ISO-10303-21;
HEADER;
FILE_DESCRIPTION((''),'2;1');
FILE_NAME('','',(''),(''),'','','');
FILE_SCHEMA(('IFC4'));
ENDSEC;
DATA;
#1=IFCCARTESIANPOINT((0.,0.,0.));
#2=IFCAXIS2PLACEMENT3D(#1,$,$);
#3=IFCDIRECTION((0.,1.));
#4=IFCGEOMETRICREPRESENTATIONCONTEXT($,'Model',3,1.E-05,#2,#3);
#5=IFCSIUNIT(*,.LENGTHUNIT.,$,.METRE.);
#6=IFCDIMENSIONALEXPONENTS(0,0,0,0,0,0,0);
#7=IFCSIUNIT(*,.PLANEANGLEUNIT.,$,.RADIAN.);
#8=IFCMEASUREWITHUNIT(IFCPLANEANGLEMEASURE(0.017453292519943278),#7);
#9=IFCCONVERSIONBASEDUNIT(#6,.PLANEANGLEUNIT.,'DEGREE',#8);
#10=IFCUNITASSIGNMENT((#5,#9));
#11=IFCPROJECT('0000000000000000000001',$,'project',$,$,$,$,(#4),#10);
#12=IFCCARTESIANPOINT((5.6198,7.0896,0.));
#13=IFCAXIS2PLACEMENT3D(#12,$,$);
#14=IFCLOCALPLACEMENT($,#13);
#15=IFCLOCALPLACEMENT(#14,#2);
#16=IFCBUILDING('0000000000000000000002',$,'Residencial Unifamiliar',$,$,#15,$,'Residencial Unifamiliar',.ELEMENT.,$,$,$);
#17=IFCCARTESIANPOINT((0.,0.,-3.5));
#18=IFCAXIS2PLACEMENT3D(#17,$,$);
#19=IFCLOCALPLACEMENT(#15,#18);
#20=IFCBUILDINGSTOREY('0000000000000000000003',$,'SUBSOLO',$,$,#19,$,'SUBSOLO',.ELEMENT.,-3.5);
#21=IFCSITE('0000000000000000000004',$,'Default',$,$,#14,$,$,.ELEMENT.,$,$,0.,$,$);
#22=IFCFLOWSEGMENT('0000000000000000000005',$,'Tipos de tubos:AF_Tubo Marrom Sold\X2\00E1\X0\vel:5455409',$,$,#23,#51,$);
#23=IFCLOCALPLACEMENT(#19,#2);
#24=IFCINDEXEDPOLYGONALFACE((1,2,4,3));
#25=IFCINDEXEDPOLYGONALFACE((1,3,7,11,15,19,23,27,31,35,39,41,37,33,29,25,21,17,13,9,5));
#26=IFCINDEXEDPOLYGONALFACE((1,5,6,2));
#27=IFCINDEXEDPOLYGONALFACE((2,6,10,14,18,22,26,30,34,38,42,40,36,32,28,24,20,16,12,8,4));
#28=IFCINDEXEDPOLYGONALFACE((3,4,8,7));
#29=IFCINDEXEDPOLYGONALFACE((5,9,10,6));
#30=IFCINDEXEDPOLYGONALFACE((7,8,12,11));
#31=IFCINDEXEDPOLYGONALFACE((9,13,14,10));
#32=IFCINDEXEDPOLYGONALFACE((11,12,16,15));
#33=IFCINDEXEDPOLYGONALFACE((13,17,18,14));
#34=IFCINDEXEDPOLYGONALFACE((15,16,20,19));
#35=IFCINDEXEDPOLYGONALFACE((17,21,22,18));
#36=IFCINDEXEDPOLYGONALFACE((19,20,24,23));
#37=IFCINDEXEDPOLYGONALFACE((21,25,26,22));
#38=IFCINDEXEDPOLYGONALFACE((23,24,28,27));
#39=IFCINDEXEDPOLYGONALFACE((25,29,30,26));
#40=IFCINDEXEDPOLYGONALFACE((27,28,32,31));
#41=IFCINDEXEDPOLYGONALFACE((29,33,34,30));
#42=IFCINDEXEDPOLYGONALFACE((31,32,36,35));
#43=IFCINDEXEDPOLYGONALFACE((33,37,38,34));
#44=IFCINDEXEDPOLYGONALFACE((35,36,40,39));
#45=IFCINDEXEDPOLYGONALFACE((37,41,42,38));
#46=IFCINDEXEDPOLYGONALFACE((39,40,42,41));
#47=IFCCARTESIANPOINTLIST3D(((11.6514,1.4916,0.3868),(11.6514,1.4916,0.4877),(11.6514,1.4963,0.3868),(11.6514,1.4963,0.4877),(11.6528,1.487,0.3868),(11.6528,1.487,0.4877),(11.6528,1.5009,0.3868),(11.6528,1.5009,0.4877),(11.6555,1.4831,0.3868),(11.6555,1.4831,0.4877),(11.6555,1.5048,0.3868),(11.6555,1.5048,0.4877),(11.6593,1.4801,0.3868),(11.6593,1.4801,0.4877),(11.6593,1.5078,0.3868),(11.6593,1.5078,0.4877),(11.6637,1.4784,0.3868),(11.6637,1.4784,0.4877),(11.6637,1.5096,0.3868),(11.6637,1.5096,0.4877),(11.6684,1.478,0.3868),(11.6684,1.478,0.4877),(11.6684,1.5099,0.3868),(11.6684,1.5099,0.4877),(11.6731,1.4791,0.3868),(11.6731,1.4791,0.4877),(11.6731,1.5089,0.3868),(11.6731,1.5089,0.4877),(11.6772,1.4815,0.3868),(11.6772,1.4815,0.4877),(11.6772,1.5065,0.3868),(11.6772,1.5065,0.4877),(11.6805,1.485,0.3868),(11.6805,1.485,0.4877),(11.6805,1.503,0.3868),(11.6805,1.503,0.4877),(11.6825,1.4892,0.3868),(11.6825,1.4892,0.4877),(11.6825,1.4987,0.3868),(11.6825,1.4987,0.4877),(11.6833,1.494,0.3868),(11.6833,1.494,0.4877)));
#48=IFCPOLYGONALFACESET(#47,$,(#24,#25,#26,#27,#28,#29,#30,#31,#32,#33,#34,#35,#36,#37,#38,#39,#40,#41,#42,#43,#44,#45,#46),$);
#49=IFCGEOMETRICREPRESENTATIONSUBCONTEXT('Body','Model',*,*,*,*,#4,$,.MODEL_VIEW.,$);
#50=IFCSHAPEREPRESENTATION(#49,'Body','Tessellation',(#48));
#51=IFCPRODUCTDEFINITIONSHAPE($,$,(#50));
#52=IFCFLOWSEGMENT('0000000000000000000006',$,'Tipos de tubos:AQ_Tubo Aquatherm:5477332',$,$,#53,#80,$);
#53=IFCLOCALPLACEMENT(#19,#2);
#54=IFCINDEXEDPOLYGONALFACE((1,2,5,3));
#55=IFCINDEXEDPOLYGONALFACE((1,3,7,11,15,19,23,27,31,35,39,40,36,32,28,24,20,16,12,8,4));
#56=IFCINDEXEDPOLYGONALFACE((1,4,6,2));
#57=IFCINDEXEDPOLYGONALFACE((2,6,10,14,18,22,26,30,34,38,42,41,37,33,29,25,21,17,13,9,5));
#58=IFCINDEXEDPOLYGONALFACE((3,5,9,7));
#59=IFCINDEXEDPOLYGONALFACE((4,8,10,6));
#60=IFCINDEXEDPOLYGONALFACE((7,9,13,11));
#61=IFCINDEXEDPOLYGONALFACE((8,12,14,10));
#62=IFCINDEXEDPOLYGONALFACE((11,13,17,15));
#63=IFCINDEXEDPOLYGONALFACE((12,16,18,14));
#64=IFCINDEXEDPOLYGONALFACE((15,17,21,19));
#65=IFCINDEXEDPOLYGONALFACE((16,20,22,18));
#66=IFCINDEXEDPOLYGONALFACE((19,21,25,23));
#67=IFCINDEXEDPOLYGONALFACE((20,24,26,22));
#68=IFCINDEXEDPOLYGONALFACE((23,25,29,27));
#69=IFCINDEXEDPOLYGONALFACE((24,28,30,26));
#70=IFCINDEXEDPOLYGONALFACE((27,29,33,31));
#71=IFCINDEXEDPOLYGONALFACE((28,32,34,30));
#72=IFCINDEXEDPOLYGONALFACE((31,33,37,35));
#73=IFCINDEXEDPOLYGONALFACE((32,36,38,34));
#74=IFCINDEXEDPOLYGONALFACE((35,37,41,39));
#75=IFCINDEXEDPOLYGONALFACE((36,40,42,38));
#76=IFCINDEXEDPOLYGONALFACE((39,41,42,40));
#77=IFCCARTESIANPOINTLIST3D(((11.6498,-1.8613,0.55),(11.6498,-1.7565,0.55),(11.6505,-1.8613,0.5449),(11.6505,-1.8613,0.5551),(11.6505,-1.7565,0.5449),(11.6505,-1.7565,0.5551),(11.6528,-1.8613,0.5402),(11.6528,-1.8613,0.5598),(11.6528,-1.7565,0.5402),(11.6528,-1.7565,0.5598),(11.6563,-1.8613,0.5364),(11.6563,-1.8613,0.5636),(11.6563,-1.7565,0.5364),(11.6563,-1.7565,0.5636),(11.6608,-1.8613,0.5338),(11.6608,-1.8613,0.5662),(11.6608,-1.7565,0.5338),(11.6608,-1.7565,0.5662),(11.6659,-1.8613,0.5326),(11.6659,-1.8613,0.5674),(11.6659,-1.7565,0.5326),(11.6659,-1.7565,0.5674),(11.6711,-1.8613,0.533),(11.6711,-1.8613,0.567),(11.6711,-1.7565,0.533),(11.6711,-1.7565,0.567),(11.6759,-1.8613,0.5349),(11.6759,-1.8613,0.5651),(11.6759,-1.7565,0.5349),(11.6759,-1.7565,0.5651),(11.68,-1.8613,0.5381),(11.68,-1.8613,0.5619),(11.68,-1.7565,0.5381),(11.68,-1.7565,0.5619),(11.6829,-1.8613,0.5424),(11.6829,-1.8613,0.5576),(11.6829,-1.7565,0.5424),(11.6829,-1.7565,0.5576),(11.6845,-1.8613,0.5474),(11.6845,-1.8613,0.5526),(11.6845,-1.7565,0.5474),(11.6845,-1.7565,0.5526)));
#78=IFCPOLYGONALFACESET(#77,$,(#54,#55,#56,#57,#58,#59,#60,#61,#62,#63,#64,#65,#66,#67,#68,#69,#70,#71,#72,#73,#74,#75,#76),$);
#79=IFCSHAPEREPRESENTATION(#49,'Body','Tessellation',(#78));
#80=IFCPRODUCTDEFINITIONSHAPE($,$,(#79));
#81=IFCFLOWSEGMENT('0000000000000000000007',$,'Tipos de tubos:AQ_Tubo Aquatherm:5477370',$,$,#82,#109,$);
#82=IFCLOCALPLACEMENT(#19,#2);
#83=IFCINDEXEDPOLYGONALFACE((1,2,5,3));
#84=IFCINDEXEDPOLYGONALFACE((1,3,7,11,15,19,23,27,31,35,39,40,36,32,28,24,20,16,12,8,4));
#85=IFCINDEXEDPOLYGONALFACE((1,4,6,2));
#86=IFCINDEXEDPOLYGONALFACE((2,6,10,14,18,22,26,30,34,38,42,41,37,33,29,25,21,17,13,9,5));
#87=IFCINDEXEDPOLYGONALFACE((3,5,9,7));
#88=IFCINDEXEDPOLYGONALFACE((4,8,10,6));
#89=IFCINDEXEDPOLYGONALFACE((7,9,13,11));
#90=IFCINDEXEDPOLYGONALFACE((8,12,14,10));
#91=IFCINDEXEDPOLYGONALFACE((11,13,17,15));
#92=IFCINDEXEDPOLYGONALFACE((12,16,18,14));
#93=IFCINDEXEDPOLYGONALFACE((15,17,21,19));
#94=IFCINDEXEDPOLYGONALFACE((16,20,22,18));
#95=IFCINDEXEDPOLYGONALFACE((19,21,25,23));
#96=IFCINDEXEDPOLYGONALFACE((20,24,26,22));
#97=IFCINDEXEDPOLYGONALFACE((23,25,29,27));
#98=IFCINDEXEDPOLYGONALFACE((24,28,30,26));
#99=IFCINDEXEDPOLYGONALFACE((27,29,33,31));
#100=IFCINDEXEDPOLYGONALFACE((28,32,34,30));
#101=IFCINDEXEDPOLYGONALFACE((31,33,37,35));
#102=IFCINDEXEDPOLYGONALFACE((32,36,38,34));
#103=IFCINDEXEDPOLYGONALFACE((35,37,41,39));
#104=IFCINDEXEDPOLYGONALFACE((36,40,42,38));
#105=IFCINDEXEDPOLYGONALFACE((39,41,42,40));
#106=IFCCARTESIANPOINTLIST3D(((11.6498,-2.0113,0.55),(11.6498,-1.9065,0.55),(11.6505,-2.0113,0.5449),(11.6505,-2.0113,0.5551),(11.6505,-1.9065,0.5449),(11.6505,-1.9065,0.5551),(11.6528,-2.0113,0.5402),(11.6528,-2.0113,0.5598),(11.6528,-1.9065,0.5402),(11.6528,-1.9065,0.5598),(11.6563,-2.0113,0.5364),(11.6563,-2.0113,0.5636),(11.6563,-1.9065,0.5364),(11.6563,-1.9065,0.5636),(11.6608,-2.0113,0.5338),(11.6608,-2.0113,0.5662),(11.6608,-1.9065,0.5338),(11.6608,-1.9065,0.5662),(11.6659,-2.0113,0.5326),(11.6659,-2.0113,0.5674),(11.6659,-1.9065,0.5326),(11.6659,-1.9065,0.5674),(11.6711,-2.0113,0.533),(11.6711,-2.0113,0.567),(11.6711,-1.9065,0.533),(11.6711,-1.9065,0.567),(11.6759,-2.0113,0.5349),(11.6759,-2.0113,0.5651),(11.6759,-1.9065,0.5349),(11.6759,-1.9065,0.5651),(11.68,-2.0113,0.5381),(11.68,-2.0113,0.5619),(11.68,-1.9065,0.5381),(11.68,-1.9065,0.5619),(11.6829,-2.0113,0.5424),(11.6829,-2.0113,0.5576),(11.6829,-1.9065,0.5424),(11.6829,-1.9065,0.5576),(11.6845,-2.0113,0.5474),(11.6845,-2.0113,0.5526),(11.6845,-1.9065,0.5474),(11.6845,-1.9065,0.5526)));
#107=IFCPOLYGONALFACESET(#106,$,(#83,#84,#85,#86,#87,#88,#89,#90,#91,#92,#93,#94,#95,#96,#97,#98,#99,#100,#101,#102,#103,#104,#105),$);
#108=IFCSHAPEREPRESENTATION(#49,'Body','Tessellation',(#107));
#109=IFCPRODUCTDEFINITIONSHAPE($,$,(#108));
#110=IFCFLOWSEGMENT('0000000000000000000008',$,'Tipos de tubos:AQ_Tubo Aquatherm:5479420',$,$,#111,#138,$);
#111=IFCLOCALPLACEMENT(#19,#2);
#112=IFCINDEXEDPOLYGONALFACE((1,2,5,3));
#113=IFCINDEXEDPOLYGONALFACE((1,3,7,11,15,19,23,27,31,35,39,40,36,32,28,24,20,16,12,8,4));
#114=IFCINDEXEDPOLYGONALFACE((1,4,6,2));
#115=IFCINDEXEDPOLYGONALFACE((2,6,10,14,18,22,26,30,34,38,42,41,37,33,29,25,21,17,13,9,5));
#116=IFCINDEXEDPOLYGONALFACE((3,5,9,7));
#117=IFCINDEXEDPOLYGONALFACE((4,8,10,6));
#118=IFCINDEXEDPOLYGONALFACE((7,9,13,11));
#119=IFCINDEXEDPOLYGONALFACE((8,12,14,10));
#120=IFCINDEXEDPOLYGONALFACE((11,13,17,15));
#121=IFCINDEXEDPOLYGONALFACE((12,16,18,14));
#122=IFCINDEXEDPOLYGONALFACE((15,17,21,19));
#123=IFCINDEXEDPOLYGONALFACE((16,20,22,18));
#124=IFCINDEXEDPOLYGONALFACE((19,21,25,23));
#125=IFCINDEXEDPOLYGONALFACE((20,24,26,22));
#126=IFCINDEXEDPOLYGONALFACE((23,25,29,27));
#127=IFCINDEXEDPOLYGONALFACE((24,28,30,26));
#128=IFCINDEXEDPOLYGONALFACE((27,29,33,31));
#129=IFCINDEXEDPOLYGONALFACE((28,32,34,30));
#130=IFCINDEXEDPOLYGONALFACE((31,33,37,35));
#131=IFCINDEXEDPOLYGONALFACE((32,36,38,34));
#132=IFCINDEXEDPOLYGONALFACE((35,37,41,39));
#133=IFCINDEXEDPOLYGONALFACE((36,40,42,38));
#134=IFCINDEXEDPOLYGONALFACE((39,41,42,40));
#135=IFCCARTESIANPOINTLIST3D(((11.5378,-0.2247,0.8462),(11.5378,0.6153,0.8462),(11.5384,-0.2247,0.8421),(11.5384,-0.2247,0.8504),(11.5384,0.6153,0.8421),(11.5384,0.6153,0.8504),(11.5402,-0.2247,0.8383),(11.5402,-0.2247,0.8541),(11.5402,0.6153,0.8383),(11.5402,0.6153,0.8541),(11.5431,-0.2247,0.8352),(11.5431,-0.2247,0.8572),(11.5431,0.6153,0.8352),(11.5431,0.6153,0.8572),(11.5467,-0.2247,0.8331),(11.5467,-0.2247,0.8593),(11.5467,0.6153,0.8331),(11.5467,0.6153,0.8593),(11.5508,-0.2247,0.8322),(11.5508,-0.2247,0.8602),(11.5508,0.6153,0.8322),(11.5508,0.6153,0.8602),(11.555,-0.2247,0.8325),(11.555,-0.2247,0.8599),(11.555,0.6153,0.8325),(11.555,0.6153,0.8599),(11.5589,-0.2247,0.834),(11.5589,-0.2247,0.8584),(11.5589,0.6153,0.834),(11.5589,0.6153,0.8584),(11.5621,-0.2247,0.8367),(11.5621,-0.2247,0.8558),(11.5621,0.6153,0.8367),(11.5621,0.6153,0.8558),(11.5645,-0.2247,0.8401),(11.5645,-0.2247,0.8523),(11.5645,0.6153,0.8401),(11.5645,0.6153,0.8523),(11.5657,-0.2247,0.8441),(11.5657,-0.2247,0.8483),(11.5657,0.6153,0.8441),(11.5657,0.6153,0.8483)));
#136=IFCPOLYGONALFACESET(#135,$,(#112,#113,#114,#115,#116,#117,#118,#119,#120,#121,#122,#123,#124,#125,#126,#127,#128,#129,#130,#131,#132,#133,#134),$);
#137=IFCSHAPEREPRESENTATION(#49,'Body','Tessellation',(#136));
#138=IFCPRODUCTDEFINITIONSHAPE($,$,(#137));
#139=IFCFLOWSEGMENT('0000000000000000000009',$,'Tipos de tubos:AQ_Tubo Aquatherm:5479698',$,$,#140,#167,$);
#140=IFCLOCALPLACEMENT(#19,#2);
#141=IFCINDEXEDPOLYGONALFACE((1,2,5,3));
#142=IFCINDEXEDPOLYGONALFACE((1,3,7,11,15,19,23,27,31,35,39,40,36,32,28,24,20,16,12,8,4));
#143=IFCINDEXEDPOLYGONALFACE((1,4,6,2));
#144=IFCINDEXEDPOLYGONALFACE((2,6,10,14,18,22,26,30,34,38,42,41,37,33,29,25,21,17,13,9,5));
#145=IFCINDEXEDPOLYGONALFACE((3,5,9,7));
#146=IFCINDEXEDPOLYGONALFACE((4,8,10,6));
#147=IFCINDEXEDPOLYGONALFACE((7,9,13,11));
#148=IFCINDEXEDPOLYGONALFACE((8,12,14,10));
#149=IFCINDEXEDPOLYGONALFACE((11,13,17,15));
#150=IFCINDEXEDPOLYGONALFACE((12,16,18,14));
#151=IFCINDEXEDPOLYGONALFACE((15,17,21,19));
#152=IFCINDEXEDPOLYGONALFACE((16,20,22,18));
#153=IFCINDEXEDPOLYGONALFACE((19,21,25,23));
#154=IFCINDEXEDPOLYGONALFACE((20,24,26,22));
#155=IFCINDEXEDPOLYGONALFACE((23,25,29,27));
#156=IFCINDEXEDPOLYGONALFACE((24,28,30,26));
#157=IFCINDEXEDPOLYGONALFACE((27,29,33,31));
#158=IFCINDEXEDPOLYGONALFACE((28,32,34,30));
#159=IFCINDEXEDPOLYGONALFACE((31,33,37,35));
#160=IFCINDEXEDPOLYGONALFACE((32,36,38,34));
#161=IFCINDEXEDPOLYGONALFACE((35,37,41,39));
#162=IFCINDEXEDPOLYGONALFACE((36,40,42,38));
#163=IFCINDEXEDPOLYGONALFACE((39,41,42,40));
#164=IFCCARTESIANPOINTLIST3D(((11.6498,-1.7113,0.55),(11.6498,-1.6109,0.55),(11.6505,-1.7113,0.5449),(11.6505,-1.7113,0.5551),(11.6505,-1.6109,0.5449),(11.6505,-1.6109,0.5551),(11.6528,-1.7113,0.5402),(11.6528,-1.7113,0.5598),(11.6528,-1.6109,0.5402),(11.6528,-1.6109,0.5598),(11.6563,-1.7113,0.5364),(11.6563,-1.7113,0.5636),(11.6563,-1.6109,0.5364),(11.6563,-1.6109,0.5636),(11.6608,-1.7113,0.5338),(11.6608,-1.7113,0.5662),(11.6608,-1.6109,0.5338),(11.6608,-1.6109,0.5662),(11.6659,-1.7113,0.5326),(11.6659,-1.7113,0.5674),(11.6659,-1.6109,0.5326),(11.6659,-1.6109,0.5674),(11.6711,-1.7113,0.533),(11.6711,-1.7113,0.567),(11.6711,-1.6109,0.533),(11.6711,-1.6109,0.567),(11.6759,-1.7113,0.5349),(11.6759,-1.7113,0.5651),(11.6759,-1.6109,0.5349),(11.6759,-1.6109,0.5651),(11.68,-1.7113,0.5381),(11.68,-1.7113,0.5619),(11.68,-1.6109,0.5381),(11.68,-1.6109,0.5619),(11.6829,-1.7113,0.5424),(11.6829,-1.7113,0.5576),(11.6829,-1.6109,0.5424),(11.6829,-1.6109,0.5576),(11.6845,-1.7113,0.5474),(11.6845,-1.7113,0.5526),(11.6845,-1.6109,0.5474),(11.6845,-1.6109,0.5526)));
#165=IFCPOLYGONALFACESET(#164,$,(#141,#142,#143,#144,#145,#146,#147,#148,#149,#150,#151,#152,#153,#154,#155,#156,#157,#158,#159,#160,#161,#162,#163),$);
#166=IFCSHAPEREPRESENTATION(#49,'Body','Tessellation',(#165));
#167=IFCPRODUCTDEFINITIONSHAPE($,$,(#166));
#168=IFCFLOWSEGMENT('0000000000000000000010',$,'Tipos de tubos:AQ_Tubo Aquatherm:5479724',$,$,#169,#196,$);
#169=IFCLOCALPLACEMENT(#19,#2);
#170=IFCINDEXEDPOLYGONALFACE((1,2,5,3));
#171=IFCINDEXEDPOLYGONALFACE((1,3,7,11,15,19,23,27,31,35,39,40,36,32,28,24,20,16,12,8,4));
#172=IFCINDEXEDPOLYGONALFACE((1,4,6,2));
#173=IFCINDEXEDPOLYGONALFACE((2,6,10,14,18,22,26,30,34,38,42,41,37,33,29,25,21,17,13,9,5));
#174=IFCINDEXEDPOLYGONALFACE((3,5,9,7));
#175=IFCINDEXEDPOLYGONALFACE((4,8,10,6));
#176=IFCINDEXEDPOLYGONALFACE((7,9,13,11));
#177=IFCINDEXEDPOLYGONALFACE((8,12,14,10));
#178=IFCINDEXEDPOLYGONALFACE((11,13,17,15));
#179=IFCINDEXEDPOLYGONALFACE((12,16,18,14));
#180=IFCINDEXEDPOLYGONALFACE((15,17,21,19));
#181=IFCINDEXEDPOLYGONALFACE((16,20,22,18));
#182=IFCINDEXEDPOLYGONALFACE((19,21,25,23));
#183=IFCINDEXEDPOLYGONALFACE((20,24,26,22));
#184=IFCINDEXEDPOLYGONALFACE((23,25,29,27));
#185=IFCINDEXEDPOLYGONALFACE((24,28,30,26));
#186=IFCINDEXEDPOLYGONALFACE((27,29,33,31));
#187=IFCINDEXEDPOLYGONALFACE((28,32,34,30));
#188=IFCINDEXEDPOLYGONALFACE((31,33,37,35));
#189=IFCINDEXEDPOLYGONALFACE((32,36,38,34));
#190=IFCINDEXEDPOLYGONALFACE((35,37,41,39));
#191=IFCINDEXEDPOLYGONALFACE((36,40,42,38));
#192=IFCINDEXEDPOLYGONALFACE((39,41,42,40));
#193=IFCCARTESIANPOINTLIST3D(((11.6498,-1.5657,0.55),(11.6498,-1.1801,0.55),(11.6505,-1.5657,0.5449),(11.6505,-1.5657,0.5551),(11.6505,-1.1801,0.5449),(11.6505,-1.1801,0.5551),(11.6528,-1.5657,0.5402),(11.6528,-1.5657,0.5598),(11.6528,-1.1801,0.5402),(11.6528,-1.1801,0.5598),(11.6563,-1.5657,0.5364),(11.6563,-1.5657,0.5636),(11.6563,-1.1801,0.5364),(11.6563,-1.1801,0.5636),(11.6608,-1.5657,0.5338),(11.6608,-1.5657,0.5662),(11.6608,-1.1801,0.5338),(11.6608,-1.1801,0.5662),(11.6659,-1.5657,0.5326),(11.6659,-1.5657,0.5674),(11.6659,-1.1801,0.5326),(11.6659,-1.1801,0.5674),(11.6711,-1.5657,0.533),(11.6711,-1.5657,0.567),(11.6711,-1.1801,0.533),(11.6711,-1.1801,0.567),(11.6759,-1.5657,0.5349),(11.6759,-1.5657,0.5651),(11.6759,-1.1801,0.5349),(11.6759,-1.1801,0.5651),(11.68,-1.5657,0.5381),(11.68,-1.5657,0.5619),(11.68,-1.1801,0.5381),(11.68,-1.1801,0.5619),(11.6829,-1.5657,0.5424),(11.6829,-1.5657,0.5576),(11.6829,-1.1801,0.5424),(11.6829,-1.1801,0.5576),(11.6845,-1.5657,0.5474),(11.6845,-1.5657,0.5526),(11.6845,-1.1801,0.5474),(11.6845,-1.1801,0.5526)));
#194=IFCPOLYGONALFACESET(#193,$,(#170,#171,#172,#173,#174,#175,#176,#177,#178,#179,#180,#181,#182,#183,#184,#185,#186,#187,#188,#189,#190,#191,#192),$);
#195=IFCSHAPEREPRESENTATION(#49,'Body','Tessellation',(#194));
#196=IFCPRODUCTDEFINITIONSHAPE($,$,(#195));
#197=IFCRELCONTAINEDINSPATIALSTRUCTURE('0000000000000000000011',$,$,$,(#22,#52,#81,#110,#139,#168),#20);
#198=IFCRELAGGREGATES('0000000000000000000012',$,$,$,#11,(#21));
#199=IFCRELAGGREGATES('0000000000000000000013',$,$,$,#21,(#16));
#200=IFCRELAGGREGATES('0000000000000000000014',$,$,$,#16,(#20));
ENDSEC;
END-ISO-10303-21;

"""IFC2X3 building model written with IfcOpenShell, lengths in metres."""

from ifc_helpers import new_model, entity, si_unit, converted_unit, direction, frame, frame_2d, origin, origin_2d_with_axis, place, context, subcontext, project, spatial, circle, extrude, element, save


model = new_model("IFC2X3")

# Units and contexts
model_context = context("Model", 3, precision=1e-05, world=origin(), true_north=direction((0.0, 1.0)))
body_context = subcontext(model_context, "Body", "Model", "MODEL_VIEW")
ifc_project = project(units=[si_unit("LENGTHUNIT", "METRE"), converted_unit("PLANEANGLEUNIT", "DEGREE", entity("IfcPlaneAngleMeasure", 0.017453292519943278), si_unit("PLANEANGLEUNIT", "RADIAN"), dimensions=[0, 0, 0, 0, 0, 0, 0])], contexts=[model_context])

# Site, building, storey
site_placement = place(None, frame((5.6198, 7.0896, 0.0)))
site = spatial("IfcSite", under=ifc_project, at=site_placement, Name="Default", CompositionType="ELEMENT", RefElevation=0.0)
building_placement = place(site_placement, origin())
building = spatial("IfcBuilding", under=site, at=building_placement, Name="Residencial Unifamiliar", LongName="Residencial Unifamiliar", CompositionType="ELEMENT")
storey_placement = place(building_placement, frame((0.0, 0.0, -3.5)))
storey = spatial("IfcBuildingStorey", under=building, at=storey_placement, Name="SUBSOLO", LongName="SUBSOLO", CompositionType="ELEMENT", Elevation=-3.5)

# Flow segments
flow_segment_1_placement = place(storey_placement, origin())
element("IfcFlowSegment", 1, at=flow_segment_1_placement, inside=storey, Name="Tipos de tubos:AF_Tubo Marrom Soldável:5455409", context=body_context, shape_type="SweptSolid", body=[
    extrude(circle(Radius=0.016, at=origin_2d_with_axis()), frame((11.6673, 1.494, 0.3868)), (0.0, 0.0, 1.0), 0.1009),
])
flow_segment_2_placement = place(storey_placement, origin())
element("IfcFlowSegment", 2, at=flow_segment_2_placement, inside=storey, Name="Tipos de tubos:AQ_Tubo Aquatherm:5477332", context=body_context, shape_type="SweptSolid", body=[
    extrude(circle(Radius=0.0175, at=origin_2d_with_axis()), frame((11.6672, -1.8613, 0.55), z_axis=(0.0, 1.0, 0.0), x_axis=(-1.0, 0.0, 0.0)), (0.0, 0.0, 1.0), 0.1047),
])
flow_segment_3_placement = place(storey_placement, origin())
element("IfcFlowSegment", 3, at=flow_segment_3_placement, inside=storey, Name="Tipos de tubos:AQ_Tubo Aquatherm:5477370", context=body_context, shape_type="SweptSolid", body=[
    extrude(circle(Radius=0.0175, at=origin_2d_with_axis()), frame((11.6672, -2.0113, 0.55), z_axis=(0.0, 1.0, 0.0), x_axis=(-1.0, 0.0, 0.0)), (0.0, 0.0, 1.0), 0.1049),
])
flow_segment_4_placement = place(storey_placement, origin())
element("IfcFlowSegment", 4, at=flow_segment_4_placement, inside=storey, Name="Tipos de tubos:AQ_Tubo Aquatherm:5479420", context=body_context, shape_type="SweptSolid", body=[
    extrude(circle(Radius=0.0141, at=frame_2d((0.0, 0.0), x_axis=(1.0, 0.0))), frame((11.5518, -0.2247, 0.8462), z_axis=(0.0, 1.0, 0.0), x_axis=(-1.0, 0.0, 0.0)), (0.0, 0.0, 1.0), 0.84),
])
flow_segment_5_placement = place(storey_placement, origin())
element("IfcFlowSegment", 5, at=flow_segment_5_placement, inside=storey, Name="Tipos de tubos:AQ_Tubo Aquatherm:5479698", context=body_context, shape_type="SweptSolid", body=[
    extrude(circle(Radius=0.0175, at=origin_2d_with_axis()), frame((11.6672, -1.7113, 0.55), z_axis=(0.0, 1.0, 0.0), x_axis=(-1.0, 0.0, 0.0)), (0.0, 0.0, 1.0), 0.1004),
])
flow_segment_6_placement = place(storey_placement, origin())
element("IfcFlowSegment", 6, at=flow_segment_6_placement, inside=storey, Name="Tipos de tubos:AQ_Tubo Aquatherm:5479724", context=body_context, shape_type="SweptSolid", body=[
    extrude(circle(Radius=0.0175, at=origin_2d_with_axis()), frame((11.6672, -1.5657, 0.55), z_axis=(0.0, 1.0, 0.0), x_axis=(-1.0, 0.0, 0.0)), (0.0, 0.0, 1.0), 0.3856),
])

save(model, "model.ifc")
